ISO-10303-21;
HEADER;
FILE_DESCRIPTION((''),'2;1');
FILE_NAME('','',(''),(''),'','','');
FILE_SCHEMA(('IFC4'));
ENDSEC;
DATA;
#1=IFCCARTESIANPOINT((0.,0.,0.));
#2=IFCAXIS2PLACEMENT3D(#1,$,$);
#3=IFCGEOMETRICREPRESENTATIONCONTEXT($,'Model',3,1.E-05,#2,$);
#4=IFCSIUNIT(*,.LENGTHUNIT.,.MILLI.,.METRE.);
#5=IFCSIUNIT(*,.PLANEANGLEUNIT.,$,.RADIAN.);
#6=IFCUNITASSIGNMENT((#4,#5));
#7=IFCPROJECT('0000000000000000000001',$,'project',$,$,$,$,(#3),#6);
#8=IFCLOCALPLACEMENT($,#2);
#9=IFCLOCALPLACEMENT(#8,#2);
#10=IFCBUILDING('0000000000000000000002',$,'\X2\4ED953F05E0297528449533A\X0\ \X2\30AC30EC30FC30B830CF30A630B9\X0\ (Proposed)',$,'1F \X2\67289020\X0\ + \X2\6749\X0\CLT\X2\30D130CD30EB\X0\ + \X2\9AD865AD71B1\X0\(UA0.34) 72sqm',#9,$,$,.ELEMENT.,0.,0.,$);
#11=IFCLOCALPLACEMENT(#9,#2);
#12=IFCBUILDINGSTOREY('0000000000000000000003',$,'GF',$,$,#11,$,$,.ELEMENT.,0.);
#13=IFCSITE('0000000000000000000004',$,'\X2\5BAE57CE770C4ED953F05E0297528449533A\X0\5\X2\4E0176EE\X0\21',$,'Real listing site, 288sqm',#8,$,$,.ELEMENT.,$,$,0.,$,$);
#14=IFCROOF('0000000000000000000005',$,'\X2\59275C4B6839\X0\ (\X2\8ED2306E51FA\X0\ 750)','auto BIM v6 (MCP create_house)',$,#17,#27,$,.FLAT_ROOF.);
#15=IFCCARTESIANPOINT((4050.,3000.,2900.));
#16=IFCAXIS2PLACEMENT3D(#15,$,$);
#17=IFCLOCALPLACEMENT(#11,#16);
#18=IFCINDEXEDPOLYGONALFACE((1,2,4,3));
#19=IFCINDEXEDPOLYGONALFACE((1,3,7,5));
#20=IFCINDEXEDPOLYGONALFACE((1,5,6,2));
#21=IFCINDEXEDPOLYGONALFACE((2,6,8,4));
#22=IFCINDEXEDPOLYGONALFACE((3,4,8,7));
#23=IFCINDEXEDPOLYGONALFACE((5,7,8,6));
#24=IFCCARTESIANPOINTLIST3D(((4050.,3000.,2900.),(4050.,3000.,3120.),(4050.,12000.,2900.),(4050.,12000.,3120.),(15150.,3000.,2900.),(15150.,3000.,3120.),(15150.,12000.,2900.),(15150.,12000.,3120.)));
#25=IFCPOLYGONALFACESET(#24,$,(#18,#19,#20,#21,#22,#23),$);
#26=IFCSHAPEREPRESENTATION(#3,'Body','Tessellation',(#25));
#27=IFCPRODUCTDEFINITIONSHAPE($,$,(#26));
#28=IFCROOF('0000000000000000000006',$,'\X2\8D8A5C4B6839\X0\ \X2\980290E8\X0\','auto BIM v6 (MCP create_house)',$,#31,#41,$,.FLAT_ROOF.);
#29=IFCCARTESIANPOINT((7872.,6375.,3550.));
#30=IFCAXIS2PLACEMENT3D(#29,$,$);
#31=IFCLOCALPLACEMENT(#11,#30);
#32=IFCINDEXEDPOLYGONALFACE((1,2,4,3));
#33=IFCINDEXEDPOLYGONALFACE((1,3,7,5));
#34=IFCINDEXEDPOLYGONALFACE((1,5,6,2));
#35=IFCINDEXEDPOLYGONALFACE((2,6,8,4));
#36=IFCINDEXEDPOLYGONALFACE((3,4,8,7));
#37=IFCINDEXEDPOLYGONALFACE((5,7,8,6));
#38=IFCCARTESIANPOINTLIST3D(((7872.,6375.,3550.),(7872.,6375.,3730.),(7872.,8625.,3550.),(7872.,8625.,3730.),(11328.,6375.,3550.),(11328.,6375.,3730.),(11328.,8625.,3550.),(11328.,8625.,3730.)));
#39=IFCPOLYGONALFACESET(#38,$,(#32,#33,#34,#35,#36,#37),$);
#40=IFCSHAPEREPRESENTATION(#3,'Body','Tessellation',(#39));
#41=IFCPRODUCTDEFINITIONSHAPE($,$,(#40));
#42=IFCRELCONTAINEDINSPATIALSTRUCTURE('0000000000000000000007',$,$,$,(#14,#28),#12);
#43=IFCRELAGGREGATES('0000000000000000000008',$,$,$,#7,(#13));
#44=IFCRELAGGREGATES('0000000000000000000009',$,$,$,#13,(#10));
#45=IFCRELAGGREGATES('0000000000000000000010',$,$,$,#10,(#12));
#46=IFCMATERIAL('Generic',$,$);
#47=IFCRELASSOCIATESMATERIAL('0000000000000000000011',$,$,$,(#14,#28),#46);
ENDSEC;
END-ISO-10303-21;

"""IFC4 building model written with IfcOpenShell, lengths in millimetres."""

from ifc_helpers import new_model, si_unit, frame, frame_2d, origin, place, context, project, spatial, rectangle, extrude, material, element, save


model = new_model("IFC4")

# Units and contexts
model_context = context("Model", 3, precision=1e-05, world=origin())
ifc_project = project(units=[si_unit("LENGTHUNIT", "METRE", prefix="MILLI"), si_unit("PLANEANGLEUNIT", "RADIAN")], contexts=[model_context])

# Site, building, storey
site_placement = place(None, origin())
site = spatial("IfcSite", under=ifc_project, at=site_placement, Name="宮城県仙台市青葉区5丁目21", ObjectType="Real listing site, 288sqm", CompositionType="ELEMENT", RefElevation=0.0)
building_placement = place(site_placement, origin())
building = spatial("IfcBuilding", under=site, at=building_placement, Name="仙台市青葉区 ガレージハウス (Proposed)", ObjectType="1F 木造 + 杉CLTパネル + 高断熱(UA0.34) 72sqm", CompositionType="ELEMENT", ElevationOfRefHeight=0.0, ElevationOfTerrain=0.0)
storey_placement = place(building_placement, origin())
storey = spatial("IfcBuildingStorey", under=building, at=storey_placement, Name="GF", CompositionType="ELEMENT", Elevation=0.0)

# Shared definitions
ifc_material = material(Name="Generic")

# Roofs
roof_1_placement = place(storey_placement, frame((4050.0, 3000.0, 2900.0)))
element("IfcRoof", 1, at=roof_1_placement, inside=storey, material=ifc_material, Name="大屋根 (軒の出 750)", Description="auto BIM v6 (MCP create_house)", PredefinedType="FLAT_ROOF", context=model_context, shape_type="SweptSolid", body=[
    extrude(rectangle(XDim=11100.0, YDim=9000.0, at=frame_2d((5550.0, 4500.0))), frame((4050.0, 3000.0, 2900.0)), (0.0, 0.0, 1.0), 220.0),
])
roof_2_placement = place(storey_placement, frame((7872.0, 6375.0, 3550.0)))
element("IfcRoof", 2, at=roof_2_placement, inside=storey, material=ifc_material, Name="越屋根 頂部", Description="auto BIM v6 (MCP create_house)", PredefinedType="FLAT_ROOF", context=model_context, shape_type="SweptSolid", body=[
    extrude(rectangle(XDim=3456.0, YDim=2250.0, at=frame_2d((1728.0, 1125.0))), frame((7872.0, 6375.0, 3550.0)), (0.0, 0.0, 1.0), 180.0),
])

save(model, "model.ifc")
